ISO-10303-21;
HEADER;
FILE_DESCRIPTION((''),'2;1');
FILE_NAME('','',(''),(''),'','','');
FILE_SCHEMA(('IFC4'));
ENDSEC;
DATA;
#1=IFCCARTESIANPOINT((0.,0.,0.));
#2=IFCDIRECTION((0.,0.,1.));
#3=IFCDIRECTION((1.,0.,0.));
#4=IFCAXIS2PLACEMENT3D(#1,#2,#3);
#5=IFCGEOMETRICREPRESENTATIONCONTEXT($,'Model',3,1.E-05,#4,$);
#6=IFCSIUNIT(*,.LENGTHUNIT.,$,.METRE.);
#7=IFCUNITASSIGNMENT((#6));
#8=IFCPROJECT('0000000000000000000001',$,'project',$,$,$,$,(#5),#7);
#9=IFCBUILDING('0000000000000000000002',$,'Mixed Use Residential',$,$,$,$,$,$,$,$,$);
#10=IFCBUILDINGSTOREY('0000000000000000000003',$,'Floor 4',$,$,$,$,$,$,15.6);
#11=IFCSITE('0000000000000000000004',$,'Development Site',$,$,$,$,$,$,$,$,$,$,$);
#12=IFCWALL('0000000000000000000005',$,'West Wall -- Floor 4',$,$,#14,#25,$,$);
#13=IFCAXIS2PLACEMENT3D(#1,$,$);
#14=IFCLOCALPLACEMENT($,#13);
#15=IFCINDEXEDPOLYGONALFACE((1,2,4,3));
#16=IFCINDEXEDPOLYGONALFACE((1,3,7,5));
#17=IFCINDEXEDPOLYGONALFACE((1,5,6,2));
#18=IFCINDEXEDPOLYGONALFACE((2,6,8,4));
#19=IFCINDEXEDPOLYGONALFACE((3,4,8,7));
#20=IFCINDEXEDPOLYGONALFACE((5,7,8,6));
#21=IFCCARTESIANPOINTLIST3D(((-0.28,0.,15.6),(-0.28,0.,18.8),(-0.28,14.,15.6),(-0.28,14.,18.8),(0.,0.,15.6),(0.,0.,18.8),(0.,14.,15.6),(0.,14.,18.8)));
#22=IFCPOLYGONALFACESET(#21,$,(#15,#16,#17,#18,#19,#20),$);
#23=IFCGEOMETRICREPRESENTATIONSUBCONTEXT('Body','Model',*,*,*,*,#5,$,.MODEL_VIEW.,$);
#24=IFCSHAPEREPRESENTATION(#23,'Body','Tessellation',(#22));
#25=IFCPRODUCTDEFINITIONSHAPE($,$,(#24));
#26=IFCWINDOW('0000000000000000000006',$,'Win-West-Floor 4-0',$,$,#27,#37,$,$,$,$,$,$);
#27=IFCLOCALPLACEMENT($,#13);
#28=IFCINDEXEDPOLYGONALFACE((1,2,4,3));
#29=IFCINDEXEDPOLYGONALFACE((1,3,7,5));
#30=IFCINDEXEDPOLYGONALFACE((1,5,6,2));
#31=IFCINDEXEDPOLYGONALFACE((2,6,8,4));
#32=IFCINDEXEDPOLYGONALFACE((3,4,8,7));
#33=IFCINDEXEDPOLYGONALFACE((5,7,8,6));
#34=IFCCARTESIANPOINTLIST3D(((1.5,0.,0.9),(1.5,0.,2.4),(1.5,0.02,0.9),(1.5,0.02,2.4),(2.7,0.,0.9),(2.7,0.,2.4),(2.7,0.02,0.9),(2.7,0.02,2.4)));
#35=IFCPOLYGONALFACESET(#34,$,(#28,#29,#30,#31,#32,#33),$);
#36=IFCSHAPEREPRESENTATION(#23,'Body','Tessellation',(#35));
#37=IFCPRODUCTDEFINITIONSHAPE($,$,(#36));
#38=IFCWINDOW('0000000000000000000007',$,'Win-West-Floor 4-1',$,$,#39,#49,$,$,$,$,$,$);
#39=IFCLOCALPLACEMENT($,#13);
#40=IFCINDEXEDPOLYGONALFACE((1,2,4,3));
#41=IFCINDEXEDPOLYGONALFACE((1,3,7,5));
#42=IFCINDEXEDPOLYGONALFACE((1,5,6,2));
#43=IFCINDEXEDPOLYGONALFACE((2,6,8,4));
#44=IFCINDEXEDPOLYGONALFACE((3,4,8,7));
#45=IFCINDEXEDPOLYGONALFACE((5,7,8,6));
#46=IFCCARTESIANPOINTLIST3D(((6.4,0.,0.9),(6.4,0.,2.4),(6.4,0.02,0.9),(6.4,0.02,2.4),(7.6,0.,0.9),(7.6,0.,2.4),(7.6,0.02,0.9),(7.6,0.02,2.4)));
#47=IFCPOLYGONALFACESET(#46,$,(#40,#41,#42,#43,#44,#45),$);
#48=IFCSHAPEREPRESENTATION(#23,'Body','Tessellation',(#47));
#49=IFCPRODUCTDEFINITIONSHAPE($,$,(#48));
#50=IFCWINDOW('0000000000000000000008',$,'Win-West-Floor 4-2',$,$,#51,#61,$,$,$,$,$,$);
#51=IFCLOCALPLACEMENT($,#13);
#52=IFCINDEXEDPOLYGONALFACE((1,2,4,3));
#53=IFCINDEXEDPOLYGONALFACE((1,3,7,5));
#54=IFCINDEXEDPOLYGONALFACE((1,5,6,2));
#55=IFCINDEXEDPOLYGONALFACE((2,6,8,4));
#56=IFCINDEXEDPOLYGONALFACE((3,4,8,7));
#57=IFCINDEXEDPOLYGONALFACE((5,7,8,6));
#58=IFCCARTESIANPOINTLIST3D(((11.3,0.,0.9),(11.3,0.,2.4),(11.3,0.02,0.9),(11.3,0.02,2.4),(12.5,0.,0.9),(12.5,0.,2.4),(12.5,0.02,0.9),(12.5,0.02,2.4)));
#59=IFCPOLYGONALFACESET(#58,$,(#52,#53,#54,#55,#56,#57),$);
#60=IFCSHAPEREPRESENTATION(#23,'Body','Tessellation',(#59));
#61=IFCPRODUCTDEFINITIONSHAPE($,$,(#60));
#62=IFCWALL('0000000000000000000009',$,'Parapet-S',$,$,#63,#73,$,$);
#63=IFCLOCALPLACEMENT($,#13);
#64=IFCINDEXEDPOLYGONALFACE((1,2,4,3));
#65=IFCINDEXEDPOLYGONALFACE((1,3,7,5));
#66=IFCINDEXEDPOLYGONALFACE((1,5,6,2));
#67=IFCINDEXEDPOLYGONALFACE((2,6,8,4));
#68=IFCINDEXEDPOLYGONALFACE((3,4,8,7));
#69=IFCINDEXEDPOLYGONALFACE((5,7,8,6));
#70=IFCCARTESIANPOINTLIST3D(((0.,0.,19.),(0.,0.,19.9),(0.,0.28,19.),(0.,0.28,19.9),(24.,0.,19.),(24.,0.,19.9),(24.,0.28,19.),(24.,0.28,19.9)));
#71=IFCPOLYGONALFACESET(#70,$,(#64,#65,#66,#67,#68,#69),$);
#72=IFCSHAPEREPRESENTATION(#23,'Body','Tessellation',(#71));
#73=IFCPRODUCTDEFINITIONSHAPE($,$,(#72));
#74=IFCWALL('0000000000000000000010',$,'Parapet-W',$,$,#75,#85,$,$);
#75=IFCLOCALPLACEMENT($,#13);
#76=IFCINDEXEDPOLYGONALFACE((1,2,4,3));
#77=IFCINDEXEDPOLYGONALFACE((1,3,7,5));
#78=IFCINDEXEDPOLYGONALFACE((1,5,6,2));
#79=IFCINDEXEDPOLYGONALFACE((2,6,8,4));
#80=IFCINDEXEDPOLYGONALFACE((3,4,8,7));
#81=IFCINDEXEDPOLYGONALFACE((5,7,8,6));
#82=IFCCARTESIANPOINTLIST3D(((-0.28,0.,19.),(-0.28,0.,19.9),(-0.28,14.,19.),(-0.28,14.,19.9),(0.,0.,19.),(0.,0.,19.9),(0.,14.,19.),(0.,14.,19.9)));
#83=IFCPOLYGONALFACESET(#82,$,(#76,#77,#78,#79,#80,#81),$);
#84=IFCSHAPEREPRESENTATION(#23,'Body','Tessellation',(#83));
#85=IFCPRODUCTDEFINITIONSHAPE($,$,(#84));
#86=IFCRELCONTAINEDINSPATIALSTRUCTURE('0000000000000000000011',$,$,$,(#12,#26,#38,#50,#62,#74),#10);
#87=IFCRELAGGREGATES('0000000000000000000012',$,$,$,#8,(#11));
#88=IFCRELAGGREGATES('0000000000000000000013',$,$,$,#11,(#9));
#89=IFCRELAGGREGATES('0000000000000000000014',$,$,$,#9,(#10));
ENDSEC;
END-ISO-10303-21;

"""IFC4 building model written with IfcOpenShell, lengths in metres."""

from ifc_helpers import new_model, si_unit, frame, origin_with_axes, place, context, subcontext, project, spatial, indexed_curve, outline, extrude, element, fill, save


model = new_model("IFC4")

# Units and contexts
model_context = context("Model", 3, precision=1e-05, world=origin_with_axes())
body_context = subcontext(model_context, "Body", "Model", "MODEL_VIEW")
ifc_project = project(units=[si_unit("LENGTHUNIT", "METRE")], contexts=[model_context])

# Site, building, storey
site = spatial("IfcSite", under=ifc_project, Name="Development Site")
building = spatial("IfcBuilding", under=site, Name="Mixed Use Residential")
storey = spatial("IfcBuildingStorey", under=building, Name="Floor 4", Elevation=15.6)

# Wall, openings, windows
wall_1_placement = place(None, frame((0.0, 0.0, 15.6), z_axis=(0.0, 0.0, 1.0), x_axis=(0.0, 1.0, 0.0)))
wall_1 = element("IfcWall", 1, at=wall_1_placement, inside=storey, Name="West Wall -- Floor 4", context=body_context, shape_type="SweptSolid", body=[
    extrude(outline(indexed_curve([(0.0, 0.0), (0.0, 0.28), (14.0, 0.28), (14.0, 0.0), (0.0, 0.0)], self_intersect=False)), origin_with_axes(), (0.0, 0.0, 1.0), 3.2),
])
opening_1_placement = place(wall_1_placement, frame((0.0, -1.5, -14.7), z_axis=(0.0, 0.0, 1.0), x_axis=(0.0, -1.0, 0.0)))
opening_1 = element("IfcOpeningElement", 2, at=opening_1_placement, cuts=wall_1, context=body_context, shape_type="SweptSolid", body=[
    extrude(outline(indexed_curve([(0.0, 0.0), (0.0, 0.28), (1.2, 0.28), (1.2, 0.0), (0.0, 0.0)], self_intersect=False)), origin_with_axes(), (0.0, 0.0, 1.0), 1.5),
])
opening_2_placement = place(wall_1_placement, frame((0.0, -6.4, -14.7), z_axis=(0.0, 0.0, 1.0), x_axis=(0.0, -1.0, 0.0)))
opening_2 = element("IfcOpeningElement", 3, at=opening_2_placement, cuts=wall_1, context=body_context, shape_type="SweptSolid", body=[
    extrude(outline(indexed_curve([(0.0, 0.0), (0.0, 0.28), (1.2, 0.28), (1.2, 0.0), (0.0, 0.0)], self_intersect=False)), origin_with_axes(), (0.0, 0.0, 1.0), 1.5),
])
opening_3_placement = place(wall_1_placement, frame((0.0, -11.3, -14.7), z_axis=(0.0, 0.0, 1.0), x_axis=(0.0, -1.0, 0.0)))
opening_3 = element("IfcOpeningElement", 4, at=opening_3_placement, cuts=wall_1, context=body_context, shape_type="SweptSolid", body=[
    extrude(outline(indexed_curve([(0.0, 0.0), (0.0, 0.28), (1.2, 0.28), (1.2, 0.0), (0.0, 0.0)], self_intersect=False)), origin_with_axes(), (0.0, 0.0, 1.0), 1.5),
])
window_1_placement = place(None, frame((1.5, 0.0, 0.9), z_axis=(0.0, 0.0, 1.0), x_axis=(1.0, 0.0, 0.0)))
window_1 = element("IfcWindow", 5, at=window_1_placement, inside=storey, Name="Win-West-Floor 4-0", context=body_context, shape_type="SweptSolid", body=[
    extrude(outline(indexed_curve([(0.0, 0.0), (0.0, 0.02), (1.2, 0.02), (1.2, 0.0), (0.0, 0.0)], self_intersect=False)), origin_with_axes(), (0.0, 0.0, 1.0), 1.5),
])
fill(opening_1, window_1)
window_2_placement = place(None, frame((6.4, 0.0, 0.9), z_axis=(0.0, 0.0, 1.0), x_axis=(1.0, 0.0, 0.0)))
window_2 = element("IfcWindow", 6, at=window_2_placement, inside=storey, Name="Win-West-Floor 4-1", context=body_context, shape_type="SweptSolid", body=[
    extrude(outline(indexed_curve([(0.0, 0.0), (0.0, 0.02), (1.2, 0.02), (1.2, 0.0), (0.0, 0.0)], self_intersect=False)), origin_with_axes(), (0.0, 0.0, 1.0), 1.5),
])
fill(opening_2, window_2)
window_3_placement = place(None, frame((11.3, 0.0, 0.9), z_axis=(0.0, 0.0, 1.0), x_axis=(1.0, 0.0, 0.0)))
window_3 = element("IfcWindow", 7, at=window_3_placement, inside=storey, Name="Win-West-Floor 4-2", context=body_context, shape_type="SweptSolid", body=[
    extrude(outline(indexed_curve([(0.0, 0.0), (0.0, 0.02), (1.2, 0.02), (1.2, 0.0), (0.0, 0.0)], self_intersect=False)), origin_with_axes(), (0.0, 0.0, 1.0), 1.5),
])
fill(opening_3, window_3)

# Walls
wall_2_placement = place(None, frame((0.0, 0.0, 19.0), z_axis=(0.0, 0.0, 1.0), x_axis=(1.0, 0.0, 0.0)))
element("IfcWall", 8, at=wall_2_placement, inside=storey, Name="Parapet-S", context=body_context, shape_type="SweptSolid", body=[
    extrude(outline(indexed_curve([(0.0, 0.0), (0.0, 0.28), (24.0, 0.28), (24.0, 0.0), (0.0, 0.0)], self_intersect=False)), origin_with_axes(), (0.0, 0.0, 1.0), 0.9),
])
wall_3_placement = place(None, frame((0.0, 0.0, 19.0), z_axis=(0.0, 0.0, 1.0), x_axis=(0.0, 1.0, 0.0)))
element("IfcWall", 9, at=wall_3_placement, inside=storey, Name="Parapet-W", context=body_context, shape_type="SweptSolid", body=[
    extrude(outline(indexed_curve([(0.0, 0.0), (0.0, 0.28), (14.0, 0.28), (14.0, 0.0), (0.0, 0.0)], self_intersect=False)), origin_with_axes(), (0.0, 0.0, 1.0), 0.9),
])

save(model, "model.ifc")
